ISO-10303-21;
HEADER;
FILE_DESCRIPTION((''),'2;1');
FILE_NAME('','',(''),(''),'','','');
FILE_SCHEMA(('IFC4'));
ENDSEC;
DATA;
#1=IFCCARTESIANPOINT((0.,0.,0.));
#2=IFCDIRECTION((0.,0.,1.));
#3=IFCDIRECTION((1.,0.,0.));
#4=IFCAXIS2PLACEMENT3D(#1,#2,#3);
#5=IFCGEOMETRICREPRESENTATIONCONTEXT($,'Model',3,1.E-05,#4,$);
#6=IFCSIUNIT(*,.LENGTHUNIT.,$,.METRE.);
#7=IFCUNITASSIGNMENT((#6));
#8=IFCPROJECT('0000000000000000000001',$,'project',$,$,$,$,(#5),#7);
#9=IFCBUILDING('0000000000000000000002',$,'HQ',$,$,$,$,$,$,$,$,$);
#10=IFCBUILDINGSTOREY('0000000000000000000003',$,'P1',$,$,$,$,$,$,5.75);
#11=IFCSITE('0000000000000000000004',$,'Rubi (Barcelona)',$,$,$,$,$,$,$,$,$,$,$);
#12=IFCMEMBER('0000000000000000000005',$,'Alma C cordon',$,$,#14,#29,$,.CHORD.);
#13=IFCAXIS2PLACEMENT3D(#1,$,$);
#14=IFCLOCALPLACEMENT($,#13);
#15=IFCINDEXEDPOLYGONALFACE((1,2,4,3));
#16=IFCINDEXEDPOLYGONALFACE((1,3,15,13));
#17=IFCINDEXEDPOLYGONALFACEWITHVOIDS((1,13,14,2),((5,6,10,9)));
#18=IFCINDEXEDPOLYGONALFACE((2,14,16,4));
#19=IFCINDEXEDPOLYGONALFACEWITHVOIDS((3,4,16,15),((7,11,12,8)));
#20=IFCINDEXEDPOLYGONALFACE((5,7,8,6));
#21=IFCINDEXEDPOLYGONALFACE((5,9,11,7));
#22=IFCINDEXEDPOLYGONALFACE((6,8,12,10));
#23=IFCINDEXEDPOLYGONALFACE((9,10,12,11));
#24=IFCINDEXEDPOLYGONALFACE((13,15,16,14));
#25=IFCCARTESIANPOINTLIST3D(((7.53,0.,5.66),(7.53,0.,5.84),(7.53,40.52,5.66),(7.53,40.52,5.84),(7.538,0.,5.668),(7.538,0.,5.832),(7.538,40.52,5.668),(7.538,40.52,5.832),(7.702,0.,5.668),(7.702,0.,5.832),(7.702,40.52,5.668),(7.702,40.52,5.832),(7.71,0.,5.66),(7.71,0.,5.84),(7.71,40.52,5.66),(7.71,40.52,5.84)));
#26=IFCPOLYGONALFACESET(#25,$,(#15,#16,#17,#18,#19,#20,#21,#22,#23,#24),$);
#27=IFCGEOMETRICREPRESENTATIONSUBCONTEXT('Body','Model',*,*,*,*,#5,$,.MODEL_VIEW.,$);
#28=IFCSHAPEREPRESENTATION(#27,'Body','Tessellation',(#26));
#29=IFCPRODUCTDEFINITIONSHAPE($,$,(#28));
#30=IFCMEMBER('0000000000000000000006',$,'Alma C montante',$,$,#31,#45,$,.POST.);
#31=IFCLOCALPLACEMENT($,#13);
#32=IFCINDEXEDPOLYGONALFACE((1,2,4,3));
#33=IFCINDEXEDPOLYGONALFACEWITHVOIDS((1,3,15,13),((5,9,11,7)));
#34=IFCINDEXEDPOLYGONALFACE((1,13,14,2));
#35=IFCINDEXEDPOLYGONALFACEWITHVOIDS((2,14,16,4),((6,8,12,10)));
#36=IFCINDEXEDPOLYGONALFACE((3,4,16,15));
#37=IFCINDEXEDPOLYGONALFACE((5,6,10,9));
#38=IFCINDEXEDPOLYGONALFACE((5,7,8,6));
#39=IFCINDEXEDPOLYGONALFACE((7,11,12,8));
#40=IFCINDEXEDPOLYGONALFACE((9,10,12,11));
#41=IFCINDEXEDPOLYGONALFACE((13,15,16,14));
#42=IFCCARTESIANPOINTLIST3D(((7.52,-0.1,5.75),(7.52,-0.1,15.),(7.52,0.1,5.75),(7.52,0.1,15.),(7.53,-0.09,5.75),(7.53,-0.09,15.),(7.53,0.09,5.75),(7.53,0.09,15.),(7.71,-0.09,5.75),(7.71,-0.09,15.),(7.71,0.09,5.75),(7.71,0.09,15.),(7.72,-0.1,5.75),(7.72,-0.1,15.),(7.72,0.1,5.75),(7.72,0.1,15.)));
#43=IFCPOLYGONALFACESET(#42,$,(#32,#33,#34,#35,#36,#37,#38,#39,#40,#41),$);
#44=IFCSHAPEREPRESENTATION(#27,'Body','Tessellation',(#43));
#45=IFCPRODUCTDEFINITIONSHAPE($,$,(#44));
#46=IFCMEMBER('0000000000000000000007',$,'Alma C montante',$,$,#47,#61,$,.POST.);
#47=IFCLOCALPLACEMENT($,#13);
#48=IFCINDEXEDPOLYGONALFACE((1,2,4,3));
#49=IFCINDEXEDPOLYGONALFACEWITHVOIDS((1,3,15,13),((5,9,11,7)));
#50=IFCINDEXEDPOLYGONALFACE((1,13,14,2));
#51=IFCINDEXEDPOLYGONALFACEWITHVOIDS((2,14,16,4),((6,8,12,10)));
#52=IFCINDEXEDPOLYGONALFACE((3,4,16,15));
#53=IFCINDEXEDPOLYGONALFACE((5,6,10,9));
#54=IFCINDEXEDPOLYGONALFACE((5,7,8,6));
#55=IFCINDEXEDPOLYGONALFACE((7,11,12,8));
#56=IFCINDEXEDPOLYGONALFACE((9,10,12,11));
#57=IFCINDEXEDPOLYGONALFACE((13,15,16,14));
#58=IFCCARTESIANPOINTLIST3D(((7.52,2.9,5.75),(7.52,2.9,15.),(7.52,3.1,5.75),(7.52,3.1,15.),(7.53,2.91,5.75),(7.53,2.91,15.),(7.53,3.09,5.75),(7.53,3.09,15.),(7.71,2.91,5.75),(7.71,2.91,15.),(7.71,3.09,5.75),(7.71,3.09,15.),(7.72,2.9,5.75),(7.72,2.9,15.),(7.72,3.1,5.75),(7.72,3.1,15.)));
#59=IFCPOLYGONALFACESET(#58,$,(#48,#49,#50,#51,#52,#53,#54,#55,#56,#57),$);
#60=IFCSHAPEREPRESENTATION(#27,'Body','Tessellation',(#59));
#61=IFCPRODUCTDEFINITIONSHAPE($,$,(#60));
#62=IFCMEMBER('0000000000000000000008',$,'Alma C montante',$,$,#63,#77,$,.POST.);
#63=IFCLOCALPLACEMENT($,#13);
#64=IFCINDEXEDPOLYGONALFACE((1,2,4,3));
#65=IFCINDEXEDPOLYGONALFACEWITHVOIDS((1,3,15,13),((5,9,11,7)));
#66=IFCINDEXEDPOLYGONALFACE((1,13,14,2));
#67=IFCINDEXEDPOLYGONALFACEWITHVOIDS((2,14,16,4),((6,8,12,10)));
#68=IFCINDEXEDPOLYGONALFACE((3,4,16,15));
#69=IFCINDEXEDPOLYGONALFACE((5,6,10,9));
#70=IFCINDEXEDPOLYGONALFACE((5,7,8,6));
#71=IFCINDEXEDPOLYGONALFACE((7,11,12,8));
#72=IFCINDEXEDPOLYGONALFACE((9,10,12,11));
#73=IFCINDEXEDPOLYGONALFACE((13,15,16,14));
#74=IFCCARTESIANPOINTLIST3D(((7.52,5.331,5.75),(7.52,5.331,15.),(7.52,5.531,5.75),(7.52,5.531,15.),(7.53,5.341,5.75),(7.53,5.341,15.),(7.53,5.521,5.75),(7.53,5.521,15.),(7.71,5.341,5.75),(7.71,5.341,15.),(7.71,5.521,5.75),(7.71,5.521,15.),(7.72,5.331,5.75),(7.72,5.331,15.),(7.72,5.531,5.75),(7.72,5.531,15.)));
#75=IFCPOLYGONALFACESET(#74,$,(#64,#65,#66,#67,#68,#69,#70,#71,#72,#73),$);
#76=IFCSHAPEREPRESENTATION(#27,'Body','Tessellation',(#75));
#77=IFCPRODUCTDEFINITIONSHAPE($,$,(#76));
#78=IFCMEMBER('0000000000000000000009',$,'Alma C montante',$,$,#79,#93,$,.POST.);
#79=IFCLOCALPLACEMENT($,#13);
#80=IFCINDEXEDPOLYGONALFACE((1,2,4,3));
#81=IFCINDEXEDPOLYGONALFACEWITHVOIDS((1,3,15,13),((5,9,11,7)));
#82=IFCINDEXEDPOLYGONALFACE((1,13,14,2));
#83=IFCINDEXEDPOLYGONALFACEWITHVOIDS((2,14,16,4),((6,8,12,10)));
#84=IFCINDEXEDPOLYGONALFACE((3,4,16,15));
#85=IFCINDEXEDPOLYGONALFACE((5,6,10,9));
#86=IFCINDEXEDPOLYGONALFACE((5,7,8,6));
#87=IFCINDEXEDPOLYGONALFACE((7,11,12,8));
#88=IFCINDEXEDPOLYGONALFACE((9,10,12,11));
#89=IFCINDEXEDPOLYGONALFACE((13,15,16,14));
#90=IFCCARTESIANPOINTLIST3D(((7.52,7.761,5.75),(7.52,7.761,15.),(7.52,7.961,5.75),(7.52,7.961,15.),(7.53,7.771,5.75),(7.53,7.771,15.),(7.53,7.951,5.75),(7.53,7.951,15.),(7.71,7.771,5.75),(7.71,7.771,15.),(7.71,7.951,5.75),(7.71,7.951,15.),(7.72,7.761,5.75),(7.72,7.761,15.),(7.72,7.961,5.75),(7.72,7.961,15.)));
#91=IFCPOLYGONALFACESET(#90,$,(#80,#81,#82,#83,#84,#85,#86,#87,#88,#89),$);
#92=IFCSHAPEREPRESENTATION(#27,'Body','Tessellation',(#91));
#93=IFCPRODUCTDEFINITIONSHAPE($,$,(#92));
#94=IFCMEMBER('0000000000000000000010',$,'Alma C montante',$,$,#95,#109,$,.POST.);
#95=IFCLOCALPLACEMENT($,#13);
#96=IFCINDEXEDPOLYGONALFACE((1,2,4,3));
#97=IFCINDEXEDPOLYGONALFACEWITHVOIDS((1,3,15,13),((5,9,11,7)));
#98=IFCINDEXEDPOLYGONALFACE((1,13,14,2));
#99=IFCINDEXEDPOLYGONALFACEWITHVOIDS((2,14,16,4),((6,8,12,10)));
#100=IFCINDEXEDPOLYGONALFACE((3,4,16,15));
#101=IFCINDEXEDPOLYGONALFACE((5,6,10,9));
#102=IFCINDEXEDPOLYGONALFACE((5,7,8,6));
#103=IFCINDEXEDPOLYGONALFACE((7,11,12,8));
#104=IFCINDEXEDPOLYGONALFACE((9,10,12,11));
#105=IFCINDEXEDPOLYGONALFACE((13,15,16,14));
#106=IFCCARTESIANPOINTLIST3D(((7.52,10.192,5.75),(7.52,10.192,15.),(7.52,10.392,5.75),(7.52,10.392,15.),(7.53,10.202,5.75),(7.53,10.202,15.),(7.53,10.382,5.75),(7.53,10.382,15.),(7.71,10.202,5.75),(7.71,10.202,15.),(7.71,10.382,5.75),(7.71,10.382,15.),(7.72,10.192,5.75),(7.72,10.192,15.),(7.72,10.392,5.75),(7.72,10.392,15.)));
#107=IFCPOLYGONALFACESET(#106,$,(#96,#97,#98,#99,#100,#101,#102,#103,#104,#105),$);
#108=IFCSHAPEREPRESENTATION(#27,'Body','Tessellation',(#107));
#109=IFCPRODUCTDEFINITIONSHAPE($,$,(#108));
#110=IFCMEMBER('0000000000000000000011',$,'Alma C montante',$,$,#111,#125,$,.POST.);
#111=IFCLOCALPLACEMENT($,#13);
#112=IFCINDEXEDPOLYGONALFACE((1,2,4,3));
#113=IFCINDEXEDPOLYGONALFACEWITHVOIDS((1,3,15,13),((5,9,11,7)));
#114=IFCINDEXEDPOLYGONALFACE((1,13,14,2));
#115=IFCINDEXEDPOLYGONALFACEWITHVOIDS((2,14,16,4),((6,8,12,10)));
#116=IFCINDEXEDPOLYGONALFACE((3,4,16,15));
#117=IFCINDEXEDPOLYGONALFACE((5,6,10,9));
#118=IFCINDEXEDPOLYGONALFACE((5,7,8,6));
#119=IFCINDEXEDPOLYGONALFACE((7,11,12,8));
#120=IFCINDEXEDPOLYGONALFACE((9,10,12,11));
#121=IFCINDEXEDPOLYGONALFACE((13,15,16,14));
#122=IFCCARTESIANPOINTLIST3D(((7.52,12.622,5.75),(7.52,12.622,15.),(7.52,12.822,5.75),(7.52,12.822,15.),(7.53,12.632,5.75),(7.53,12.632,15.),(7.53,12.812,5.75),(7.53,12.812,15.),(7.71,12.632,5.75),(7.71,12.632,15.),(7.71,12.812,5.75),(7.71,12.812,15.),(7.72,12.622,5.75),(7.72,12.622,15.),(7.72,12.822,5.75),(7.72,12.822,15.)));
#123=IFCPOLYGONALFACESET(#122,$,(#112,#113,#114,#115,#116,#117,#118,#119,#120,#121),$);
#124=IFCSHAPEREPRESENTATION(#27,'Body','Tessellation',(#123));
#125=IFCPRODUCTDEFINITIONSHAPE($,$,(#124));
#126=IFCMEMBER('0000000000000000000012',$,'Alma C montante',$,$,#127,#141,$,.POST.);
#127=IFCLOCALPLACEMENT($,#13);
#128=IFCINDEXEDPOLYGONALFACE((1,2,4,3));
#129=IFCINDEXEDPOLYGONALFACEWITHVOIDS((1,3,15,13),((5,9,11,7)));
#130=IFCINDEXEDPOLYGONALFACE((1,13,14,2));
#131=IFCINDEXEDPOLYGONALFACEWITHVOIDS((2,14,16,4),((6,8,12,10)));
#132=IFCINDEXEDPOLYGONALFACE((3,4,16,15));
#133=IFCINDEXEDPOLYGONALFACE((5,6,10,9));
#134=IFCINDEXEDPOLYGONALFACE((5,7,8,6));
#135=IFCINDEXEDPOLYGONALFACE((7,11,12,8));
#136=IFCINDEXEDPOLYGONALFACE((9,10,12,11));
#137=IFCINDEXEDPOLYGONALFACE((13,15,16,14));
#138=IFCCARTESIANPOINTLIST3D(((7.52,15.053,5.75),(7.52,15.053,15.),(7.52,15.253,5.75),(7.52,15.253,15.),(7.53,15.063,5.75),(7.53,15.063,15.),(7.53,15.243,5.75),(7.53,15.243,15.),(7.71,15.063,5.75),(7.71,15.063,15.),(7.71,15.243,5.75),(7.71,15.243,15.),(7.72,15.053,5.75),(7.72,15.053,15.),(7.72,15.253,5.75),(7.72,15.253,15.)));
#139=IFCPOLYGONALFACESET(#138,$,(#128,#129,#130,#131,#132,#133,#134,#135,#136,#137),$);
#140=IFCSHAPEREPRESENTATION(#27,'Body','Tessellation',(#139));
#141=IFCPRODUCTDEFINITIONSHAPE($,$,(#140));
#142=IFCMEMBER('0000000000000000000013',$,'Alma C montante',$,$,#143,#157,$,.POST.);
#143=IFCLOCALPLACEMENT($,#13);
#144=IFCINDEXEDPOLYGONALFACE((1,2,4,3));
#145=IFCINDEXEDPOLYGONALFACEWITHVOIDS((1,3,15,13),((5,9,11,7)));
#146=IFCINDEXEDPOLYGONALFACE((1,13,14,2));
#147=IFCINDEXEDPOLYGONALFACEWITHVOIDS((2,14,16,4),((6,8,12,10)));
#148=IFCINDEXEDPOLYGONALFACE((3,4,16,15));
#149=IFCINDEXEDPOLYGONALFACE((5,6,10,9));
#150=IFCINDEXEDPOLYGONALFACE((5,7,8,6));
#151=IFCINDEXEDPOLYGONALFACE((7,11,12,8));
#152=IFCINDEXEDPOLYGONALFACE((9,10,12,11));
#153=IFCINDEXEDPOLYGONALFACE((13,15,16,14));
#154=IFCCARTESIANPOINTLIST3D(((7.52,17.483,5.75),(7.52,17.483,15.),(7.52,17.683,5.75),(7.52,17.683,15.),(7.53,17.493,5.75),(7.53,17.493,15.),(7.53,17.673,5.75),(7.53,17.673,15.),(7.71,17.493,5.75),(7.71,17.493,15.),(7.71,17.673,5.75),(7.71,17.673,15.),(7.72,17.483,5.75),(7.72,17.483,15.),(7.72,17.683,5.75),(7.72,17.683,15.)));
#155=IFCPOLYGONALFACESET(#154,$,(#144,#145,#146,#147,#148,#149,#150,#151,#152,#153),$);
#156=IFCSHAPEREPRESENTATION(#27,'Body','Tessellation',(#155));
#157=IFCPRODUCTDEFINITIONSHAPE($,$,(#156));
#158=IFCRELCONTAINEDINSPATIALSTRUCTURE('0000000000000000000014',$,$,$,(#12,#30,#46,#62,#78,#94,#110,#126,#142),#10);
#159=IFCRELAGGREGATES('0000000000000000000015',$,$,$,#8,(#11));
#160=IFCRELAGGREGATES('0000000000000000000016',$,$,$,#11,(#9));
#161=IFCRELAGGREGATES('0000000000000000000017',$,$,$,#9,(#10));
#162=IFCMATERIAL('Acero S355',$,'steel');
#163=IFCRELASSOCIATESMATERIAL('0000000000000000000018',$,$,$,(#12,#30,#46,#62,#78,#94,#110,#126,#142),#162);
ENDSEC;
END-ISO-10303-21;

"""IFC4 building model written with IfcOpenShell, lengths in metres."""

from ifc_helpers import new_model, si_unit, frame, origin_with_axes, place, context, subcontext, project, spatial, hollow_rectangle, extrude, material, element, save


model = new_model("IFC4")

# Units and contexts
model_context = context("Model", 3, precision=1e-05, world=origin_with_axes())
body_context = subcontext(model_context, "Body", "Model", "MODEL_VIEW")
ifc_project = project(units=[si_unit("LENGTHUNIT", "METRE")], contexts=[model_context])

# Site, building, storey
site = spatial("IfcSite", under=ifc_project, Name="Rubi (Barcelona)")
building = spatial("IfcBuilding", under=site, Name="HQ")
storey = spatial("IfcBuildingStorey", under=building, Name="P1", Elevation=5.75)

# Members
ifc_material = material(Name="Acero S355", Category="steel")
member_1_placement = place(None, origin_with_axes())
element("IfcMember", 1, at=member_1_placement, inside=storey, material=ifc_material, Name="Alma C cordon", PredefinedType="CHORD", context=body_context, shape_type="SweptSolid", body=[
    extrude(hollow_rectangle(XDim=0.18, YDim=0.18, WallThickness=0.008), frame((7.62, 0.0, 5.75), z_axis=(0.0, 1.0, 0.0), x_axis=(-1.0, 0.0, 0.0)), (0.0, 0.0, 1.0), 40.52),
])
member_2_placement = place(None, origin_with_axes())
element("IfcMember", 2, at=member_2_placement, inside=storey, material=ifc_material, Name="Alma C montante", PredefinedType="POST", context=body_context, shape_type="SweptSolid", body=[
    extrude(hollow_rectangle(XDim=0.2, YDim=0.2, WallThickness=0.01), frame((7.62, 0.0, 5.75), z_axis=(0.0, 0.0, 1.0), x_axis=(1.0, 0.0, 0.0)), (0.0, 0.0, 1.0), 9.25),
])
member_3_placement = place(None, origin_with_axes())
element("IfcMember", 3, at=member_3_placement, inside=storey, material=ifc_material, Name="Alma C montante", PredefinedType="POST", context=body_context, shape_type="SweptSolid", body=[
    extrude(hollow_rectangle(XDim=0.2, YDim=0.2, WallThickness=0.01), frame((7.62, 3.0, 5.75), z_axis=(0.0, 0.0, 1.0), x_axis=(1.0, 0.0, 0.0)), (0.0, 0.0, 1.0), 9.25),
])
member_4_placement = place(None, origin_with_axes())
element("IfcMember", 4, at=member_4_placement, inside=storey, material=ifc_material, Name="Alma C montante", PredefinedType="POST", context=body_context, shape_type="SweptSolid", body=[
    extrude(hollow_rectangle(XDim=0.2, YDim=0.2, WallThickness=0.01), frame((7.62, 5.431, 5.75), z_axis=(0.0, 0.0, 1.0), x_axis=(1.0, 0.0, 0.0)), (0.0, 0.0, 1.0), 9.25),
])
member_5_placement = place(None, origin_with_axes())
element("IfcMember", 5, at=member_5_placement, inside=storey, material=ifc_material, Name="Alma C montante", PredefinedType="POST", context=body_context, shape_type="SweptSolid", body=[
    extrude(hollow_rectangle(XDim=0.2, YDim=0.2, WallThickness=0.01), frame((7.62, 7.861, 5.75), z_axis=(0.0, 0.0, 1.0), x_axis=(1.0, 0.0, 0.0)), (0.0, 0.0, 1.0), 9.25),
])
member_6_placement = place(None, origin_with_axes())
element("IfcMember", 6, at=member_6_placement, inside=storey, material=ifc_material, Name="Alma C montante", PredefinedType="POST", context=body_context, shape_type="SweptSolid", body=[
    extrude(hollow_rectangle(XDim=0.2, YDim=0.2, WallThickness=0.01), frame((7.62, 10.292, 5.75), z_axis=(0.0, 0.0, 1.0), x_axis=(1.0, 0.0, 0.0)), (0.0, 0.0, 1.0), 9.25),
])
member_7_placement = place(None, origin_with_axes())
element("IfcMember", 7, at=member_7_placement, inside=storey, material=ifc_material, Name="Alma C montante", PredefinedType="POST", context=body_context, shape_type="SweptSolid", body=[
    extrude(hollow_rectangle(XDim=0.2, YDim=0.2, WallThickness=0.01), frame((7.62, 12.722, 5.75), z_axis=(0.0, 0.0, 1.0), x_axis=(1.0, 0.0, 0.0)), (0.0, 0.0, 1.0), 9.25),
])
member_8_placement = place(None, origin_with_axes())
element("IfcMember", 8, at=member_8_placement, inside=storey, material=ifc_material, Name="Alma C montante", PredefinedType="POST", context=body_context, shape_type="SweptSolid", body=[
    extrude(hollow_rectangle(XDim=0.2, YDim=0.2, WallThickness=0.01), frame((7.62, 15.153, 5.75), z_axis=(0.0, 0.0, 1.0), x_axis=(1.0, 0.0, 0.0)), (0.0, 0.0, 1.0), 9.25),
])
member_9_placement = place(None, origin_with_axes())
element("IfcMember", 9, at=member_9_placement, inside=storey, material=ifc_material, Name="Alma C montante", PredefinedType="POST", context=body_context, shape_type="SweptSolid", body=[
    extrude(hollow_rectangle(XDim=0.2, YDim=0.2, WallThickness=0.01), frame((7.62, 17.583, 5.75), z_axis=(0.0, 0.0, 1.0), x_axis=(1.0, 0.0, 0.0)), (0.0, 0.0, 1.0), 9.25),
])

save(model, "model.ifc")
